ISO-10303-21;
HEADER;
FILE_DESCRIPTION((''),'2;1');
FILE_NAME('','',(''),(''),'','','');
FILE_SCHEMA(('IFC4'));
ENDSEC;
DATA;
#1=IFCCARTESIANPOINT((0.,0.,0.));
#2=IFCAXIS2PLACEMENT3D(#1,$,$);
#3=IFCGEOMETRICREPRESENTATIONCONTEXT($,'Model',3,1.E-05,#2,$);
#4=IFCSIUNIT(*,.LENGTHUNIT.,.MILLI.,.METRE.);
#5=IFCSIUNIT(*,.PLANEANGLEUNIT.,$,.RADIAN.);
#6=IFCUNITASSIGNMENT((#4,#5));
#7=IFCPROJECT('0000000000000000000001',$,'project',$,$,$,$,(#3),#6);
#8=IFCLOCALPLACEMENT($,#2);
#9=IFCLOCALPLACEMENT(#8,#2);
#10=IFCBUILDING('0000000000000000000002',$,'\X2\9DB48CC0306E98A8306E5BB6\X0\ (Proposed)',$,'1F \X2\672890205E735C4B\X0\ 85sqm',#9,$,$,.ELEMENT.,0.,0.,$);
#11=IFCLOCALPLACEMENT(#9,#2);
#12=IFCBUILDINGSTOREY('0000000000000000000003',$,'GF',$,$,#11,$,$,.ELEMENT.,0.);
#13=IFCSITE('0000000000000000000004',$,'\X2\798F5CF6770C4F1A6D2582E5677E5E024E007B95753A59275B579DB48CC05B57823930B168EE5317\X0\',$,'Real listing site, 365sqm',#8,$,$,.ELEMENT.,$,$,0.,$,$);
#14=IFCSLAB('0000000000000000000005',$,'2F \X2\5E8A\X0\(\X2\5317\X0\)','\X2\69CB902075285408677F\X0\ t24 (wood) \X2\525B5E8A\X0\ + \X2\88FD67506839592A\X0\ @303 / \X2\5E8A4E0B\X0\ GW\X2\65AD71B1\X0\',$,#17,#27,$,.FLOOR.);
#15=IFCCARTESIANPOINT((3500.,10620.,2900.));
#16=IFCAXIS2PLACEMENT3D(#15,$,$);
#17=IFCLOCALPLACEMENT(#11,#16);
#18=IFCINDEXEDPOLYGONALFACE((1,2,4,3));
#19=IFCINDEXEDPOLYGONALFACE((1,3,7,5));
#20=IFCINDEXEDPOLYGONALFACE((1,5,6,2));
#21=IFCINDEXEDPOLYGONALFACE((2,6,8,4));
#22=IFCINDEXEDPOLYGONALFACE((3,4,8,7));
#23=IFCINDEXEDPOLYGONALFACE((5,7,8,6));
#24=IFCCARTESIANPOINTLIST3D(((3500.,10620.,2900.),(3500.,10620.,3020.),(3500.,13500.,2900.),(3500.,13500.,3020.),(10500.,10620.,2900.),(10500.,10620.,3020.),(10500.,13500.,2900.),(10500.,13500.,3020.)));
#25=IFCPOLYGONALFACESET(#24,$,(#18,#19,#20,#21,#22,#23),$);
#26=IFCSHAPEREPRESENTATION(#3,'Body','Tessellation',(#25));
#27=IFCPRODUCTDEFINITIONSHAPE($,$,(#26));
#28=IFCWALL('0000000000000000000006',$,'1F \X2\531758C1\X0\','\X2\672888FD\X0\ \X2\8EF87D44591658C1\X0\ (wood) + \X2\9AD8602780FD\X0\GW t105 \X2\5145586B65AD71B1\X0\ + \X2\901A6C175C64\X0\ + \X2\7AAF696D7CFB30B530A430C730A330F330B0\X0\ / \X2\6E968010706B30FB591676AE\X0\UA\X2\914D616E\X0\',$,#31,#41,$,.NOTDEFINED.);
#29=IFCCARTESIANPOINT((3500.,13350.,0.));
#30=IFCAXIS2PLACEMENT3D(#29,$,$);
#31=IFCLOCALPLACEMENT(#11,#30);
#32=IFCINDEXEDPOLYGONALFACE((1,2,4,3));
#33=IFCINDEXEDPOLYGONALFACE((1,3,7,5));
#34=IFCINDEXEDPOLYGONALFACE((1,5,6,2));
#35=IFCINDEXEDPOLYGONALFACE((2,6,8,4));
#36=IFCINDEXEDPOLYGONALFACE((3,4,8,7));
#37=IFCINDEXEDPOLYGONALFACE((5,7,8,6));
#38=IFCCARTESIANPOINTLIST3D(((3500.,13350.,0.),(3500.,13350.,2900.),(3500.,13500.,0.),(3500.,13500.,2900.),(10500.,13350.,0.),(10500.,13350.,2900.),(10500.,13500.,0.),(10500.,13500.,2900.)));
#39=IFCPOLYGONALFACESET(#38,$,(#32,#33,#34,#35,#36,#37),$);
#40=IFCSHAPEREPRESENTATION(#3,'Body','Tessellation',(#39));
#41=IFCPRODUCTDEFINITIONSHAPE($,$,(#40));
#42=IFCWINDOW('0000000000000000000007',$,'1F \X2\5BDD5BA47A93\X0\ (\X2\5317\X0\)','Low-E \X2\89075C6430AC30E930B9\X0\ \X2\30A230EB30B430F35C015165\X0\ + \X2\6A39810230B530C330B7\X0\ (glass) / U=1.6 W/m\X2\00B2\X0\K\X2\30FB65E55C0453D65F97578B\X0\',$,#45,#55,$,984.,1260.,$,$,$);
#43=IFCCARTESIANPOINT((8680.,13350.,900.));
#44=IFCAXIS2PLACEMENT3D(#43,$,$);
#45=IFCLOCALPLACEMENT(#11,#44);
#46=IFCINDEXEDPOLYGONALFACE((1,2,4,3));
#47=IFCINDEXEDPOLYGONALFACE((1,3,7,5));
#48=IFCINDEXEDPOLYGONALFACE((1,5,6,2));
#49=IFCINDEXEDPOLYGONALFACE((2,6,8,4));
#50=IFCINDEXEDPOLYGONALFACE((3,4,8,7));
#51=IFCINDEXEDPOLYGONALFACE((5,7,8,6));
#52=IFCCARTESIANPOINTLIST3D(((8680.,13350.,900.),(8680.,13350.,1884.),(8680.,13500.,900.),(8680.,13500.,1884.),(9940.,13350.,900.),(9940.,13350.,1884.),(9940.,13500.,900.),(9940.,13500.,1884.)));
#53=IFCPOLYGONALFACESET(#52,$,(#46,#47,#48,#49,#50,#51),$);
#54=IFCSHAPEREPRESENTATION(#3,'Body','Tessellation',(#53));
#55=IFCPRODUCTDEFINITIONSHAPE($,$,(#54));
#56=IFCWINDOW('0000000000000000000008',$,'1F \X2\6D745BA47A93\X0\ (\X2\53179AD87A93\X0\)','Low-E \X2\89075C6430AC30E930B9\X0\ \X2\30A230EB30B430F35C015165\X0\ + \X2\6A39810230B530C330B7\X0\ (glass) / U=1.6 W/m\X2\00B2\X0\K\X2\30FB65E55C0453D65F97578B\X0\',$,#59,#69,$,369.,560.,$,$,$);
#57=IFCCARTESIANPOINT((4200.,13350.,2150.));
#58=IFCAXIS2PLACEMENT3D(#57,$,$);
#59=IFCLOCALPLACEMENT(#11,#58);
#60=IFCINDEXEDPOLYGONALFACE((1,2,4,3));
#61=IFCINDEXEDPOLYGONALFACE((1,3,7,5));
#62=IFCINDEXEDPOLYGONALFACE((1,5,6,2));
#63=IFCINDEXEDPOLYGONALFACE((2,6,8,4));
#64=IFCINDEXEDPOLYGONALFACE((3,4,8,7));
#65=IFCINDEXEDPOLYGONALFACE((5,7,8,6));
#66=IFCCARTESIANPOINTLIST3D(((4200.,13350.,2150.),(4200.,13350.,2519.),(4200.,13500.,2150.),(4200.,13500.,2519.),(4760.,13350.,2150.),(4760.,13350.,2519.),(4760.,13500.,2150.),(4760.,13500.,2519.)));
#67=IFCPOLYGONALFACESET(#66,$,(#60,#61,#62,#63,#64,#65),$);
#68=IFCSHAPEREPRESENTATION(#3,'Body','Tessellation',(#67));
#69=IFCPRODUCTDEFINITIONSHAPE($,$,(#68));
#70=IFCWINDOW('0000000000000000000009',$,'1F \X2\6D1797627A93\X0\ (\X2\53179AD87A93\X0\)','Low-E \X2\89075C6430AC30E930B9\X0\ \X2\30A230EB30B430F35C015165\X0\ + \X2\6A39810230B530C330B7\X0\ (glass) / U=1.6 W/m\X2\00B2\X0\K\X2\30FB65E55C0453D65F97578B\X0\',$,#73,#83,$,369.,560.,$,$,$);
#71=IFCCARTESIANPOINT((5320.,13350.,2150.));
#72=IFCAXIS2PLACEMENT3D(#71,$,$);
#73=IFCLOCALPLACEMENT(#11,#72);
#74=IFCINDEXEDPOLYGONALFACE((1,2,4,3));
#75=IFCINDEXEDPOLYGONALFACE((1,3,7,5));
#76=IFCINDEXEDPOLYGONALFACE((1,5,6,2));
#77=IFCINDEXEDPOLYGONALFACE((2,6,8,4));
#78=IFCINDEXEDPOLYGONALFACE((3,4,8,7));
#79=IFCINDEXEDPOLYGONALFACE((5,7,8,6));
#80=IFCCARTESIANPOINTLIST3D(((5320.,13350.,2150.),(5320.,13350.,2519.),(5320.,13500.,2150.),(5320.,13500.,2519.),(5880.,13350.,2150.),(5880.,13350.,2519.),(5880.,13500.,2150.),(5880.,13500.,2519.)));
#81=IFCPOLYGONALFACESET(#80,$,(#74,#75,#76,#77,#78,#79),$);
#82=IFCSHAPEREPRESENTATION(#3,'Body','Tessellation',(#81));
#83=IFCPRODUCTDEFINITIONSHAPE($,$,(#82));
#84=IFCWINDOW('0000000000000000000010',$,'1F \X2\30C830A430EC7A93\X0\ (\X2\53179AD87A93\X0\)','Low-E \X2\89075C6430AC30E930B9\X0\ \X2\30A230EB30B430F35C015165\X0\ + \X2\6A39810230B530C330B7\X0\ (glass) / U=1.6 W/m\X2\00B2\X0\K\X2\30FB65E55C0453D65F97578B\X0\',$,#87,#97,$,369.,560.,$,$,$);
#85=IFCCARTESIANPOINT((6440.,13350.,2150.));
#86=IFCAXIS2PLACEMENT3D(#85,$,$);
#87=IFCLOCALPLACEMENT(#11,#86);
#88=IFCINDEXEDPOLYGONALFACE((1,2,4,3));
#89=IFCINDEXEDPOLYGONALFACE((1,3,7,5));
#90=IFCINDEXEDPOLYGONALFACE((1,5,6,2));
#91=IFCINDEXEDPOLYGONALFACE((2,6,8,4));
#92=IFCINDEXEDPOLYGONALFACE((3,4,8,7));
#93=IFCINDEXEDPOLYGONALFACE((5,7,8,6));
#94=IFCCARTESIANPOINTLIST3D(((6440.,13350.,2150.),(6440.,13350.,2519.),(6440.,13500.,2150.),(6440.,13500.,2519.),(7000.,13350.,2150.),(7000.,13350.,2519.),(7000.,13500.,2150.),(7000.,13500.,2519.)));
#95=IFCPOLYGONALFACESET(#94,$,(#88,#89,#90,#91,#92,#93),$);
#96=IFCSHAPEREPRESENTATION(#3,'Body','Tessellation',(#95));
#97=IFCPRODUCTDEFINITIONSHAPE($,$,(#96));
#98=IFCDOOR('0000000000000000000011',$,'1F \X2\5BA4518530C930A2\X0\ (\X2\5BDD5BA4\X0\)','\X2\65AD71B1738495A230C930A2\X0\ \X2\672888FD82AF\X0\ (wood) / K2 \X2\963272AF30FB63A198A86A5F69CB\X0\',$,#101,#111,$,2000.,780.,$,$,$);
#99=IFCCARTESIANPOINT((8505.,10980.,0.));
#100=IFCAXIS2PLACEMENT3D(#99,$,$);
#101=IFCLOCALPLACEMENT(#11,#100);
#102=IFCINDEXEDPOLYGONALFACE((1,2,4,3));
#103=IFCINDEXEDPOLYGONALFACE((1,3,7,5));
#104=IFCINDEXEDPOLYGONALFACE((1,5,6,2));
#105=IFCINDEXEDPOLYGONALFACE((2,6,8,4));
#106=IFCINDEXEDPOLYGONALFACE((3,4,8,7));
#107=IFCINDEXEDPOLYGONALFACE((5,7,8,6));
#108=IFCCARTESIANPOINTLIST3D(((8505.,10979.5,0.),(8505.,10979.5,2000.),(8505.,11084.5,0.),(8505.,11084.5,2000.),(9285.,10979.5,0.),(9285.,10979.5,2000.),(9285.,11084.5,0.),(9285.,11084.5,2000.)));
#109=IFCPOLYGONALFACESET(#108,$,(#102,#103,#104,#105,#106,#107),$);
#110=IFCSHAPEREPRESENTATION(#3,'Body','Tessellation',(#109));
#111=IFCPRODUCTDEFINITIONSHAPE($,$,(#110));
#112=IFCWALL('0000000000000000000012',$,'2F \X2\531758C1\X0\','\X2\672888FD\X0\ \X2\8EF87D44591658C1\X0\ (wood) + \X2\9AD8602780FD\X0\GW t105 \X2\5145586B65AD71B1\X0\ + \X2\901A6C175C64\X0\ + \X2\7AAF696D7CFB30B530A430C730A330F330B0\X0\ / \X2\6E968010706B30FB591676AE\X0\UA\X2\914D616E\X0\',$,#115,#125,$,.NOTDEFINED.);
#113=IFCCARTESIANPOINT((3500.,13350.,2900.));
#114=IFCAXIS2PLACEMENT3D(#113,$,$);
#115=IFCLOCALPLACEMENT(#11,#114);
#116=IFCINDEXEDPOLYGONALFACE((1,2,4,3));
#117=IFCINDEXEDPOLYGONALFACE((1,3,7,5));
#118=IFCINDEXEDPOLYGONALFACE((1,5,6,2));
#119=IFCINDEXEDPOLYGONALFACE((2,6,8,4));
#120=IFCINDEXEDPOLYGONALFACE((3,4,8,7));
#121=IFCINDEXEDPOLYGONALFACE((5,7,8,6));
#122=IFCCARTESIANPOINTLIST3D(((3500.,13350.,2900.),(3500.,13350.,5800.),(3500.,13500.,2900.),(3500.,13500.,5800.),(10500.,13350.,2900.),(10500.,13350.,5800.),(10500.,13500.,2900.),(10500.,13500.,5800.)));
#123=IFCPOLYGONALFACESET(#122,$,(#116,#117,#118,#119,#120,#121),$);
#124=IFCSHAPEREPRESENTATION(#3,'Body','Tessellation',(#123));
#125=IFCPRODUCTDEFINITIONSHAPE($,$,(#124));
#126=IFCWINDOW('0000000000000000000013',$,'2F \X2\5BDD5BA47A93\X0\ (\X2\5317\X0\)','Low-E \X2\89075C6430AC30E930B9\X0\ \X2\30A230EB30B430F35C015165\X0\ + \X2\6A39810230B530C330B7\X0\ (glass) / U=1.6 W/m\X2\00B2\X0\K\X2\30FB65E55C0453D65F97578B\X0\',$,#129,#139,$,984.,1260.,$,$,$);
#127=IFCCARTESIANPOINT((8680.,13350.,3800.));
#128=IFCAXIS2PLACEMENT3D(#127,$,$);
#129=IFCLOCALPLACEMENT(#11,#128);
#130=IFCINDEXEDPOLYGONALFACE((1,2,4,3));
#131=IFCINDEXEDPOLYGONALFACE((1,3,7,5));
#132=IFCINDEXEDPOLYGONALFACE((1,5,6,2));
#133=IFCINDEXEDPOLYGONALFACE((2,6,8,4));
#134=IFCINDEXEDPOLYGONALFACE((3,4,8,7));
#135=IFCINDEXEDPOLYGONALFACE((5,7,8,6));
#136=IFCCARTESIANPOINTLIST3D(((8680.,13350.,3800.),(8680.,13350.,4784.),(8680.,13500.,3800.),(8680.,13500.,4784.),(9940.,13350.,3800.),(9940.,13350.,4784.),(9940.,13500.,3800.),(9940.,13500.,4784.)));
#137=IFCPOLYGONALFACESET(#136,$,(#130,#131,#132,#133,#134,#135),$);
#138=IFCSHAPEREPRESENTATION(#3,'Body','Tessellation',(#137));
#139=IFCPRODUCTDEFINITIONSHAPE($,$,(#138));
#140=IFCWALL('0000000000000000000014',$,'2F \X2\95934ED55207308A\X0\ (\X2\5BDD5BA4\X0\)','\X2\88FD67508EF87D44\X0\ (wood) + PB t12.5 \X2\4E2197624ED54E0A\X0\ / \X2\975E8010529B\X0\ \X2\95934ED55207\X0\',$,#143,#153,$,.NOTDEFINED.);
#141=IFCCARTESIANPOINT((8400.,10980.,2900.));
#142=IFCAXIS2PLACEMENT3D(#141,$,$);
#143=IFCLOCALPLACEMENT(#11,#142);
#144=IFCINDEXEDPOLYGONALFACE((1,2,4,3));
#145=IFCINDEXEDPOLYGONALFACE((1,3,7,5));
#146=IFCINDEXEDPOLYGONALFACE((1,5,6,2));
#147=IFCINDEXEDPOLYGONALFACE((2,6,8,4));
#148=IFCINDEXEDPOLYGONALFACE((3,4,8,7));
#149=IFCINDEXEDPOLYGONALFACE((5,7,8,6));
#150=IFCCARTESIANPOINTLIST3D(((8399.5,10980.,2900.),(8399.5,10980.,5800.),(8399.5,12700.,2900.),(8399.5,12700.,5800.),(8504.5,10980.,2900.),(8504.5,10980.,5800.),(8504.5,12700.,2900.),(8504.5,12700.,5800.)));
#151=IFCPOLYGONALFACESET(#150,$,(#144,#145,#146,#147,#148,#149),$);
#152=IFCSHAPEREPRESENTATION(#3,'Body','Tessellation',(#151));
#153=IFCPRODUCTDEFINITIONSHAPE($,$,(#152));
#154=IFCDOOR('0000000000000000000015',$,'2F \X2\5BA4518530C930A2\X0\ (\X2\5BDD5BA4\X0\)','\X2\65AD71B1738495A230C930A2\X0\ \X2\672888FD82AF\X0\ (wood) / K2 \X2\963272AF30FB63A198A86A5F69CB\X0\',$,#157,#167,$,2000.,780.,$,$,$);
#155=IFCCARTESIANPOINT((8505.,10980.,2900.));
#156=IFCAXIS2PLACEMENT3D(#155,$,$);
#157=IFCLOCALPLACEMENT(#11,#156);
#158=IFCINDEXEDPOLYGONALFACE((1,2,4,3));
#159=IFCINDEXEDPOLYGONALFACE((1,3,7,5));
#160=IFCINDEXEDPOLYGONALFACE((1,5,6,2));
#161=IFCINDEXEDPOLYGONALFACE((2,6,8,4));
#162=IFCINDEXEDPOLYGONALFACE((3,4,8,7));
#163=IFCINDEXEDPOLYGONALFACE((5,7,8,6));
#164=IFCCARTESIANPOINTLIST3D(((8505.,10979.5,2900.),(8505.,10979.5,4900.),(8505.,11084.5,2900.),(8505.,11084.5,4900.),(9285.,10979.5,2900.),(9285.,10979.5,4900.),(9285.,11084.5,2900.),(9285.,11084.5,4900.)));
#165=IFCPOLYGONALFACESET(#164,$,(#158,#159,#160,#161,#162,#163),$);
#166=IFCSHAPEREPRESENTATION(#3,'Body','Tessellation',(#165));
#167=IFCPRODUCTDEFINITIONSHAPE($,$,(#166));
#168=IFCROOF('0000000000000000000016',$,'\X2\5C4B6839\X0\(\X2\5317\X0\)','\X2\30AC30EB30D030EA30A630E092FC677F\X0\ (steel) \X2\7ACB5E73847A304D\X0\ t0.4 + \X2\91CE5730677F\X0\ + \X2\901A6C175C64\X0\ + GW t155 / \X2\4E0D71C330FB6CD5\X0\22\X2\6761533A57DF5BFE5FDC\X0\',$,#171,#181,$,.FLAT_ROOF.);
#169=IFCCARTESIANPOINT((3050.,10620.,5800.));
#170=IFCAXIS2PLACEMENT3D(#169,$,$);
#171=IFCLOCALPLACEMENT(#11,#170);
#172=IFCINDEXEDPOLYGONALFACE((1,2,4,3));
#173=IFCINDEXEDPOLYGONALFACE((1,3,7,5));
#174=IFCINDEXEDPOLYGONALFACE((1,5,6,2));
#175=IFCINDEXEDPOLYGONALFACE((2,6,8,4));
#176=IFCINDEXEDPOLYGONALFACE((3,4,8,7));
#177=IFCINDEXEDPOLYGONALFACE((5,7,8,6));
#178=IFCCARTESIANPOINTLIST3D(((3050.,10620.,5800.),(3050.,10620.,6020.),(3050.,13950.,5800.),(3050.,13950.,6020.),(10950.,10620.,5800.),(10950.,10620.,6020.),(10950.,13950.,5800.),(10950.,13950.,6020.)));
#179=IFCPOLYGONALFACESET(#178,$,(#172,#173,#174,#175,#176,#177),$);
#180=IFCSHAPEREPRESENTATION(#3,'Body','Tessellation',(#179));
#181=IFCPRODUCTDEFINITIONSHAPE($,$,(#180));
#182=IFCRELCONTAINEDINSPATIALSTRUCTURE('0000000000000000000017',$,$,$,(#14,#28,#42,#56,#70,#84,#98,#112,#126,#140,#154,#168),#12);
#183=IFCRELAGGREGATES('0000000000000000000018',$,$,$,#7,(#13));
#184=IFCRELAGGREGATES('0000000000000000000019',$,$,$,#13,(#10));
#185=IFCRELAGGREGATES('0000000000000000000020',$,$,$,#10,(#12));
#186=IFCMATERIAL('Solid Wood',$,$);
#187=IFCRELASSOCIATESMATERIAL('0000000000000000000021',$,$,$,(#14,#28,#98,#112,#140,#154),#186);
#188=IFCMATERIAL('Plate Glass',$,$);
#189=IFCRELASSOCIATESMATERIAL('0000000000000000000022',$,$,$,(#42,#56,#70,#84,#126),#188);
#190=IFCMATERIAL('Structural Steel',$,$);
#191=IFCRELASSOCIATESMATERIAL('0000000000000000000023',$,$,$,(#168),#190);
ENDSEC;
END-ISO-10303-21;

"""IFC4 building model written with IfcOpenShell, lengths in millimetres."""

from ifc_helpers import new_model, si_unit, frame, frame_2d, origin, place, context, project, spatial, rectangle, extrude, material, element, fill, save


model = new_model("IFC4")

# Units and contexts
model_context = context("Model", 3, precision=1e-05, world=origin())
ifc_project = project(units=[si_unit("LENGTHUNIT", "METRE", prefix="MILLI"), si_unit("PLANEANGLEUNIT", "RADIAN")], contexts=[model_context])

# Site, building, storey
site_placement = place(None, origin())
site = spatial("IfcSite", under=ifc_project, at=site_placement, Name="福島県会津若松市一箕町大字鶴賀字船ケ森北", ObjectType="Real listing site, 365sqm", CompositionType="ELEMENT", RefElevation=0.0)
building_placement = place(site_placement, origin())
building = spatial("IfcBuilding", under=site, at=building_placement, Name="鶴賀の風の家 (Proposed)", ObjectType="1F 木造平屋 85sqm", CompositionType="ELEMENT", ElevationOfRefHeight=0.0, ElevationOfTerrain=0.0)
storey_placement = place(building_placement, origin())
storey = spatial("IfcBuildingStorey", under=building, at=storey_placement, Name="GF", CompositionType="ELEMENT", Elevation=0.0)

# Slab
ifc_material_1 = material(Name="Solid Wood")
slab_placement = place(storey_placement, frame((3500.0, 10620.0, 2900.0)))
element("IfcSlab", 1, at=slab_placement, inside=storey, material=ifc_material_1, Name="2F 床(北)", Description="構造用合板 t24 (wood) 剛床 + 製材根太 @303 / 床下 GW断熱", PredefinedType="FLOOR", context=model_context, shape_type="SweptSolid", body=[
    extrude(rectangle(XDim=7000.0, YDim=2880.0, at=frame_2d((3500.0, 1440.0))), frame((3500.0, 10620.0, 2900.0)), (0.0, 0.0, 1.0), 120.0),
])

# Wall, openings, windows
wall_1_placement = place(storey_placement, frame((3500.0, 13350.0, 0.0)))
wall_1 = element("IfcWall", 2, at=wall_1_placement, inside=storey, material=ifc_material_1, Name="1F 北壁", Description="木製 軸組外壁 (wood) + 高性能GW t105 充填断熱 + 通気層 + 窯業系サイディング / 準耐火・外皮UA配慮", PredefinedType="NOTDEFINED", context=model_context, shape_type="SweptSolid", body=[
    extrude(rectangle(XDim=7000.0, YDim=150.0, at=frame_2d((3500.0, 75.0))), frame((3500.0, 13350.0, 0.0)), (0.0, 0.0, 1.0), 2900.0),
])
opening_1_placement = place(storey_placement, frame((8680.0, 13350.0, 900.0)))
opening_1 = element("IfcOpeningElement", 3, at=opening_1_placement, cuts=wall_1, PredefinedType="NOTDEFINED", context=model_context, shape_type="SweptSolid", body=[
    extrude(rectangle(XDim=1260.0, YDim=150.0, at=frame_2d((630.0, 75.0))), frame((8680.0, 13350.0, 900.0)), (0.0, 0.0, 1.0), 984.0),
])
opening_2_placement = place(storey_placement, frame((4200.0, 13350.0, 2150.0)))
opening_2 = element("IfcOpeningElement", 4, at=opening_2_placement, cuts=wall_1, PredefinedType="NOTDEFINED", context=model_context, shape_type="SweptSolid", body=[
    extrude(rectangle(XDim=560.0, YDim=150.0, at=frame_2d((280.0, 75.0))), frame((4200.0, 13350.0, 2150.0)), (0.0, 0.0, 1.0), 369.0),
])
opening_3_placement = place(storey_placement, frame((5320.0, 13350.0, 2150.0)))
opening_3 = element("IfcOpeningElement", 5, at=opening_3_placement, cuts=wall_1, PredefinedType="NOTDEFINED", context=model_context, shape_type="SweptSolid", body=[
    extrude(rectangle(XDim=560.0, YDim=150.0, at=frame_2d((280.0, 75.0))), frame((5320.0, 13350.0, 2150.0)), (0.0, 0.0, 1.0), 369.0),
])
opening_4_placement = place(storey_placement, frame((6440.0, 13350.0, 2150.0)))
opening_4 = element("IfcOpeningElement", 6, at=opening_4_placement, cuts=wall_1, PredefinedType="NOTDEFINED", context=model_context, shape_type="SweptSolid", body=[
    extrude(rectangle(XDim=560.0, YDim=150.0, at=frame_2d((280.0, 75.0))), frame((6440.0, 13350.0, 2150.0)), (0.0, 0.0, 1.0), 369.0),
])
ifc_material_2 = material(Name="Plate Glass")
window_1_placement = place(storey_placement, frame((8680.0, 13350.0, 900.0)))
window_1 = element("IfcWindow", 7, at=window_1_placement, inside=storey, material=ifc_material_2, Name="1F 寝室窓 (北)", Description="Low-E 複層ガラス アルゴン封入 + 樹脂サッシ (glass) / U=1.6 W/m²K・日射取得型", OverallHeight=984.0, OverallWidth=1260.0, context=model_context, shape_type="SweptSolid", body=[
    extrude(rectangle(XDim=1260.0, YDim=150.0, at=frame_2d((630.0, 75.0))), frame((8680.0, 13350.0, 900.0)), (0.0, 0.0, 1.0), 984.0),
])
fill(opening_1, window_1)
window_2_placement = place(storey_placement, frame((4200.0, 13350.0, 2150.0)))
window_2 = element("IfcWindow", 8, at=window_2_placement, inside=storey, material=ifc_material_2, Name="1F 浴室窓 (北高窓)", Description="Low-E 複層ガラス アルゴン封入 + 樹脂サッシ (glass) / U=1.6 W/m²K・日射取得型", OverallHeight=369.0, OverallWidth=560.0, context=model_context, shape_type="SweptSolid", body=[
    extrude(rectangle(XDim=560.0, YDim=150.0, at=frame_2d((280.0, 75.0))), frame((4200.0, 13350.0, 2150.0)), (0.0, 0.0, 1.0), 369.0),
])
fill(opening_2, window_2)
window_3_placement = place(storey_placement, frame((5320.0, 13350.0, 2150.0)))
window_3 = element("IfcWindow", 9, at=window_3_placement, inside=storey, material=ifc_material_2, Name="1F 洗面窓 (北高窓)", Description="Low-E 複層ガラス アルゴン封入 + 樹脂サッシ (glass) / U=1.6 W/m²K・日射取得型", OverallHeight=369.0, OverallWidth=560.0, context=model_context, shape_type="SweptSolid", body=[
    extrude(rectangle(XDim=560.0, YDim=150.0, at=frame_2d((280.0, 75.0))), frame((5320.0, 13350.0, 2150.0)), (0.0, 0.0, 1.0), 369.0),
])
fill(opening_3, window_3)
window_4_placement = place(storey_placement, frame((6440.0, 13350.0, 2150.0)))
window_4 = element("IfcWindow", 10, at=window_4_placement, inside=storey, material=ifc_material_2, Name="1F トイレ窓 (北高窓)", Description="Low-E 複層ガラス アルゴン封入 + 樹脂サッシ (glass) / U=1.6 W/m²K・日射取得型", OverallHeight=369.0, OverallWidth=560.0, context=model_context, shape_type="SweptSolid", body=[
    extrude(rectangle(XDim=560.0, YDim=150.0, at=frame_2d((280.0, 75.0))), frame((6440.0, 13350.0, 2150.0)), (0.0, 0.0, 1.0), 369.0),
])
fill(opening_4, window_4)

# Door
door_1_placement = place(storey_placement, frame((8505.0, 10980.0, 0.0)))
element("IfcDoor", 11, at=door_1_placement, inside=storey, material=ifc_material_1, Name="1F 室内ドア (寝室)", Description="断熱玄関ドア 木製芯 (wood) / K2 防犯・採風機構", OverallHeight=2000.0, OverallWidth=780.0, context=model_context, shape_type="SweptSolid", body=[
    extrude(rectangle(XDim=780.0, YDim=105.0, at=frame_2d((390.0, 52.0))), frame((8505.0, 10980.0, 0.0)), (0.0, 0.0, 1.0), 2000.0),
])

# Wall, opening, window
wall_2_placement = place(storey_placement, frame((3500.0, 13350.0, 2900.0)))
wall_2 = element("IfcWall", 12, at=wall_2_placement, inside=storey, material=ifc_material_1, Name="2F 北壁", Description="木製 軸組外壁 (wood) + 高性能GW t105 充填断熱 + 通気層 + 窯業系サイディング / 準耐火・外皮UA配慮", PredefinedType="NOTDEFINED", context=model_context, shape_type="SweptSolid", body=[
    extrude(rectangle(XDim=7000.0, YDim=150.0, at=frame_2d((3500.0, 75.0))), frame((3500.0, 13350.0, 2900.0)), (0.0, 0.0, 1.0), 2900.0),
])
opening_5_placement = place(storey_placement, frame((8680.0, 13350.0, 3800.0)))
opening_5 = element("IfcOpeningElement", 13, at=opening_5_placement, cuts=wall_2, PredefinedType="NOTDEFINED", context=model_context, shape_type="SweptSolid", body=[
    extrude(rectangle(XDim=1260.0, YDim=150.0, at=frame_2d((630.0, 75.0))), frame((8680.0, 13350.0, 3800.0)), (0.0, 0.0, 1.0), 984.0),
])
window_5_placement = place(storey_placement, frame((8680.0, 13350.0, 3800.0)))
window_5 = element("IfcWindow", 14, at=window_5_placement, inside=storey, material=ifc_material_2, Name="2F 寝室窓 (北)", Description="Low-E 複層ガラス アルゴン封入 + 樹脂サッシ (glass) / U=1.6 W/m²K・日射取得型", OverallHeight=984.0, OverallWidth=1260.0, context=model_context, shape_type="SweptSolid", body=[
    extrude(rectangle(XDim=1260.0, YDim=150.0, at=frame_2d((630.0, 75.0))), frame((8680.0, 13350.0, 3800.0)), (0.0, 0.0, 1.0), 984.0),
])
fill(opening_5, window_5)

# Wall
wall_3_placement = place(storey_placement, frame((8400.0, 10980.0, 2900.0)))
element("IfcWall", 15, at=wall_3_placement, inside=storey, material=ifc_material_1, Name="2F 間仕切り (寝室)", Description="製材軸組 (wood) + PB t12.5 両面仕上 / 非耐力 間仕切", PredefinedType="NOTDEFINED", context=model_context, shape_type="SweptSolid", body=[
    extrude(rectangle(XDim=105.0, YDim=1720.0, at=frame_2d((52.0, 860.0))), frame((8400.0, 10980.0, 2900.0)), (0.0, 0.0, 1.0), 2900.0),
])

# Door
door_2_placement = place(storey_placement, frame((8505.0, 10980.0, 2900.0)))
element("IfcDoor", 16, at=door_2_placement, inside=storey, material=ifc_material_1, Name="2F 室内ドア (寝室)", Description="断熱玄関ドア 木製芯 (wood) / K2 防犯・採風機構", OverallHeight=2000.0, OverallWidth=780.0, context=model_context, shape_type="SweptSolid", body=[
    extrude(rectangle(XDim=780.0, YDim=105.0, at=frame_2d((390.0, 52.0))), frame((8505.0, 10980.0, 2900.0)), (0.0, 0.0, 1.0), 2000.0),
])

# Roof
ifc_material_3 = material(Name="Structural Steel")
roof_placement = place(storey_placement, frame((3050.0, 10620.0, 5800.0)))
element("IfcRoof", 17, at=roof_placement, inside=storey, material=ifc_material_3, Name="屋根(北)", Description="ガルバリウム鋼板 (steel) 立平葺き t0.4 + 野地板 + 通気層 + GW t155 / 不燃・法22条区域対応", PredefinedType="FLAT_ROOF", context=model_context, shape_type="SweptSolid", body=[
    extrude(rectangle(XDim=7900.0, YDim=3330.0, at=frame_2d((3950.0, 1665.0))), frame((3050.0, 10620.0, 5800.0)), (0.0, 0.0, 1.0), 220.0),
])

save(model, "model.ifc")
